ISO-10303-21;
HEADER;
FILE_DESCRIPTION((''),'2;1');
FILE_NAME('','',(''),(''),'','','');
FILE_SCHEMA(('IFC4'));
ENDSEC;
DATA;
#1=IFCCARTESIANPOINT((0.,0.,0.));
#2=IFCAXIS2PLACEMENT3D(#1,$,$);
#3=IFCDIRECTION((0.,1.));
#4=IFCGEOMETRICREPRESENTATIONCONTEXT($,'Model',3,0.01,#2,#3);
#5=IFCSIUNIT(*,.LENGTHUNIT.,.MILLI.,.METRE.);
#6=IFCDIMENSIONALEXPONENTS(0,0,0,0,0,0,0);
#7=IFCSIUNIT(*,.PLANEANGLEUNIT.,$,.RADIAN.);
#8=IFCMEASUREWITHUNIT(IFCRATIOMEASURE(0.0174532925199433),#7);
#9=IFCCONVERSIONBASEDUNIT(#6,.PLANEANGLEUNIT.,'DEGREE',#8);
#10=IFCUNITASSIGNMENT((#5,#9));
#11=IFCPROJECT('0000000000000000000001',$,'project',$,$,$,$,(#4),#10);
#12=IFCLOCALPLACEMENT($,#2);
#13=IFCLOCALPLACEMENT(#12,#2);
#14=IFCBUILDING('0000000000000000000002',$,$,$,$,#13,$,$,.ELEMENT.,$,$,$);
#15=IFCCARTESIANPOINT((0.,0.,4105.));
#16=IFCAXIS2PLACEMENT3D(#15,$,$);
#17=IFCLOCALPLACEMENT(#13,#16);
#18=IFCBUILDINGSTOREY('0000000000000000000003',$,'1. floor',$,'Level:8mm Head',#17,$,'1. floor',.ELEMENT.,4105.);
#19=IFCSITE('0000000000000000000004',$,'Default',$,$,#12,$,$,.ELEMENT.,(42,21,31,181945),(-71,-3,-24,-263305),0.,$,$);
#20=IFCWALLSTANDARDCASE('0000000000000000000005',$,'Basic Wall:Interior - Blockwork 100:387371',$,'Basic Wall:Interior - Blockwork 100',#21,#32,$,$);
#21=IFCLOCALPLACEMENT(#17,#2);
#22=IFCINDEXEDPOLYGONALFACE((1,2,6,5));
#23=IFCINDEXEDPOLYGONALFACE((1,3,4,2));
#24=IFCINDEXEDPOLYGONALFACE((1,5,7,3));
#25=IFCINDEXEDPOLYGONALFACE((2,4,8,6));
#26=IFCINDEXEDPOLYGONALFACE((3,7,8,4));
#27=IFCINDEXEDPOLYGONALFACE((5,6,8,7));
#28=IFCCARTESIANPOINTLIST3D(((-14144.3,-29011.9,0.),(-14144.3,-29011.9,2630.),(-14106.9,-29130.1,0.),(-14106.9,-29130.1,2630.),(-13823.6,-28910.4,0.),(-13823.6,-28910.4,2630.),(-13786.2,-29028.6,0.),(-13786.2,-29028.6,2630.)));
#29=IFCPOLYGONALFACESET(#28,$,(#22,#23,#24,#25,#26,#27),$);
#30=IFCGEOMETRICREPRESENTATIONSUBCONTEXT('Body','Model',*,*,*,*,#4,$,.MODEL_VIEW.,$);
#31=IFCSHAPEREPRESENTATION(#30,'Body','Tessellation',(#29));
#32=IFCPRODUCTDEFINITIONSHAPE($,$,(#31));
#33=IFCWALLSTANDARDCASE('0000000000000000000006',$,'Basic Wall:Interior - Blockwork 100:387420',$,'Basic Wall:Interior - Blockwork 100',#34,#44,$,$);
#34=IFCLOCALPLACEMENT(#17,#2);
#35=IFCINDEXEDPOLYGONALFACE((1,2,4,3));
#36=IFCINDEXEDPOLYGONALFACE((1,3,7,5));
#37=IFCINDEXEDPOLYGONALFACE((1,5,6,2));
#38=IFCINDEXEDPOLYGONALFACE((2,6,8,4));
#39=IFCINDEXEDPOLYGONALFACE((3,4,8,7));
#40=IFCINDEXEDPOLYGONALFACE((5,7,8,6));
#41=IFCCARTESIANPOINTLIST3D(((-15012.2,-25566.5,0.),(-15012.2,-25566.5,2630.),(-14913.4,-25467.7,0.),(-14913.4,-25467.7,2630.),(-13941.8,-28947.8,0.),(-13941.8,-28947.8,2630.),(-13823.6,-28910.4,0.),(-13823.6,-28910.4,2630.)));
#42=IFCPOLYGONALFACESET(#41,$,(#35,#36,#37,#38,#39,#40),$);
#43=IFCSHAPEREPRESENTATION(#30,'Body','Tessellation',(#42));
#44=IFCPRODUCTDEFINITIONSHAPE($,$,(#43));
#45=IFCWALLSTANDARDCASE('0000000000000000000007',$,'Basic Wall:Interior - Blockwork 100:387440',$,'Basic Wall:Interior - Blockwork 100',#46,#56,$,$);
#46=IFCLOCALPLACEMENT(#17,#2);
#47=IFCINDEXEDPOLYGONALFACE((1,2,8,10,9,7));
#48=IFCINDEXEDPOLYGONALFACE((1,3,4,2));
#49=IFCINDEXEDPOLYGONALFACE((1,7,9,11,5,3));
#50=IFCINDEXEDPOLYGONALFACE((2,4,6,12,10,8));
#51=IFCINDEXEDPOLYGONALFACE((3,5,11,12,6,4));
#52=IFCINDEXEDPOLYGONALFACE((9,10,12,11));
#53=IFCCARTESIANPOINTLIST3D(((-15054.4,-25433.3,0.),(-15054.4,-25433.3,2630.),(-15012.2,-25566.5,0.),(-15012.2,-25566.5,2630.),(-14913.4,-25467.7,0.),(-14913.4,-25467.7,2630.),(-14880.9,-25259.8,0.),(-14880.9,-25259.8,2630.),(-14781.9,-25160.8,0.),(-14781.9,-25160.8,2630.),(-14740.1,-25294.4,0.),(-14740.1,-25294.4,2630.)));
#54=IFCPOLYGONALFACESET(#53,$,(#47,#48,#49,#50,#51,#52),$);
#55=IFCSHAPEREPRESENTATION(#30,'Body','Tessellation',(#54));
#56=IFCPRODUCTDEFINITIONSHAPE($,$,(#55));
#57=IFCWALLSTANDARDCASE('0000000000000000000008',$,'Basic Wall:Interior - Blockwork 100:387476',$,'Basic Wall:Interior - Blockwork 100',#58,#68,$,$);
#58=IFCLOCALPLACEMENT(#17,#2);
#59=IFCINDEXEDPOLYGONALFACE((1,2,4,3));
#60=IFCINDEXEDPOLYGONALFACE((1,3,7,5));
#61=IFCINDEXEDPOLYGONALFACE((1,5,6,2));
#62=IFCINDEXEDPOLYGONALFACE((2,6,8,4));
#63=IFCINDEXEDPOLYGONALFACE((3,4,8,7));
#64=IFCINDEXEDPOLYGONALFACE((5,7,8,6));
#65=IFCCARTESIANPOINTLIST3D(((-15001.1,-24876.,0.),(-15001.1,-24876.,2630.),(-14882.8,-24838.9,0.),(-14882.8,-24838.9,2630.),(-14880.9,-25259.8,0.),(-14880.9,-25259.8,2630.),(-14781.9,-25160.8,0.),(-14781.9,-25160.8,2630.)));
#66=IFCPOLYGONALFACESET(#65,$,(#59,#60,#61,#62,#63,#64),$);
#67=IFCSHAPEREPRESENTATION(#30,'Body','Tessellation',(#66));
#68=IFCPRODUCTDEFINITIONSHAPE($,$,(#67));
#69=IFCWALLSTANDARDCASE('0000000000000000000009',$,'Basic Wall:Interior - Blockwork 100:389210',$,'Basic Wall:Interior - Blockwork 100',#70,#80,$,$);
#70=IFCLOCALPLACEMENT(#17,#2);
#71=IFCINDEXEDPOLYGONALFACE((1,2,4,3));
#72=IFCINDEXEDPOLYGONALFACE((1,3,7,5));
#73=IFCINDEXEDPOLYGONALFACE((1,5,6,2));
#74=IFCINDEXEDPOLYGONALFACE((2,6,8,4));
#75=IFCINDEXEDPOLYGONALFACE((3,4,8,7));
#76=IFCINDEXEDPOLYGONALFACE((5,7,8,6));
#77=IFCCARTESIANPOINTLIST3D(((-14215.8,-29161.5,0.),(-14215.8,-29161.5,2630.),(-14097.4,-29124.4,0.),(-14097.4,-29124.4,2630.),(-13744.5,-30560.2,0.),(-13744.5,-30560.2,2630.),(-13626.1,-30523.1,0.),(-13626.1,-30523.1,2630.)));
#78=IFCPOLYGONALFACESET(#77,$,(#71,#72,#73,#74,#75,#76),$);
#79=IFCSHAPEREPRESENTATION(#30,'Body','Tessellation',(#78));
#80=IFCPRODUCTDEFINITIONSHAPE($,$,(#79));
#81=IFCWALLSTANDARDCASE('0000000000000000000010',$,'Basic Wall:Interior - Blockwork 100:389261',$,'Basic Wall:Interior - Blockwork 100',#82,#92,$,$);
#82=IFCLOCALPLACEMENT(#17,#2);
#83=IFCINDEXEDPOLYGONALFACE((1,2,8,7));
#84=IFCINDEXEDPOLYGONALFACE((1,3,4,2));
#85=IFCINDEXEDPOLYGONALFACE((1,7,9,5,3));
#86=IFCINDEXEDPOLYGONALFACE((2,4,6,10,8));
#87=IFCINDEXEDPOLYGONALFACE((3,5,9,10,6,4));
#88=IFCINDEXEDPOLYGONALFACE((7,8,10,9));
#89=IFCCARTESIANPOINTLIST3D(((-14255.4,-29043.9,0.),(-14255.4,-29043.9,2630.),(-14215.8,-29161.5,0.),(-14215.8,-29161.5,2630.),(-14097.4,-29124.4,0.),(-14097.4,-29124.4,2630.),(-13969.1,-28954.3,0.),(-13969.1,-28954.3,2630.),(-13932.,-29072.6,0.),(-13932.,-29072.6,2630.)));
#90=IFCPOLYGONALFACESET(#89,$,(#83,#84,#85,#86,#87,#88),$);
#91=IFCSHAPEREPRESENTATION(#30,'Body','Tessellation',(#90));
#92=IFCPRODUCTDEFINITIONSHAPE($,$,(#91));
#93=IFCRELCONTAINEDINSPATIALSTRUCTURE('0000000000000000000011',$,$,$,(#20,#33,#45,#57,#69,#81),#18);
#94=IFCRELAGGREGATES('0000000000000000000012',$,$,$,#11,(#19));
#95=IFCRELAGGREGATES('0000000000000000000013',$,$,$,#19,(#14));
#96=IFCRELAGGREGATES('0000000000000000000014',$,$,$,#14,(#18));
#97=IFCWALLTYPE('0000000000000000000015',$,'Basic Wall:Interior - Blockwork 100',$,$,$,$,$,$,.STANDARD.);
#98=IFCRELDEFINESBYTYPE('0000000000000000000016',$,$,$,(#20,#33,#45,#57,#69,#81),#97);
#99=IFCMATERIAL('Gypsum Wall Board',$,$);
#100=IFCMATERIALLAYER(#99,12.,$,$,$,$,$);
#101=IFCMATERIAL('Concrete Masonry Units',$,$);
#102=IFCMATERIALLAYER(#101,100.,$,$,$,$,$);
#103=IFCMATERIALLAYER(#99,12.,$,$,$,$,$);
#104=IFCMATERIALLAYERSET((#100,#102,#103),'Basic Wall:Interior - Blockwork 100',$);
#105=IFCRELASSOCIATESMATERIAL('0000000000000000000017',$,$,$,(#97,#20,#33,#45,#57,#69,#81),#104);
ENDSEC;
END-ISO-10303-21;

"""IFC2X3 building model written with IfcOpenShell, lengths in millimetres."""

from ifc_helpers import new_model, entity, si_unit, converted_unit, direction, frame, frame_2d, origin, place, context, subcontext, project, spatial, polyline, rectangle, outline, extrude, material, layer, layer_set, layer_usage, type_object, element, save


model = new_model("IFC2X3")

# Units and contexts
model_context = context("Model", 3, precision=0.01, world=origin(), true_north=direction((0.0, 1.0)))
body_context = subcontext(model_context, "Body", "Model", "MODEL_VIEW")
ifc_project = project(units=[si_unit("LENGTHUNIT", "METRE", prefix="MILLI"), converted_unit("PLANEANGLEUNIT", "DEGREE", entity("IfcRatioMeasure", 0.0174532925199433), si_unit("PLANEANGLEUNIT", "RADIAN"), dimensions=[0, 0, 0, 0, 0, 0, 0])], contexts=[model_context])

# Site, building, storey
site_placement = place(None, origin())
site = spatial("IfcSite", under=ifc_project, at=site_placement, Name="Default", CompositionType="ELEMENT", RefLatitude=(42, 21, 31, 181945), RefLongitude=(-71, -3, -24, -263305), RefElevation=0.0)
building_placement = place(site_placement, origin())
building = spatial("IfcBuilding", under=site, at=building_placement, CompositionType="ELEMENT")
storey_placement = place(building_placement, frame((0.0, 0.0, 4105.0)))
storey = spatial("IfcBuildingStorey", under=building, at=storey_placement, Name="1. floor", ObjectType="Level:8mm Head", LongName="1. floor", CompositionType="ELEMENT", Elevation=4105.0)

# Shared definitions
ifc_material_1 = material(Name="Gypsum Wall Board")

# Walls
ifc_layer_1 = layer(ifc_material_1, 12.0)
ifc_material_2 = material(Name="Concrete Masonry Units")
ifc_layer_2 = layer(ifc_material_2, 100.0)
ifc_layer_3 = layer(ifc_material_1, 12.0)
ifc_layer_set_1 = layer_set([ifc_layer_1, ifc_layer_2, ifc_layer_3], Name="Basic Wall:Interior - Blockwork 100")
wall_type_1 = type_object("IfcWallType", Name="Basic Wall:Interior - Blockwork 100", PredefinedType="STANDARD", material=ifc_layer_set_1)
ifc_layer_usage_1 = layer_usage(ifc_layer_set_1, "AXIS2", "NEGATIVE", 62.0)
wall_1_placement = place(storey_placement, frame((-14125.6, -29071.0, 0.0), z_axis=(0.0, 0.0, 1.0), x_axis=(0.953372, 0.301797, 0.0)))
element("IfcWallStandardCase", 1, at=wall_1_placement, inside=storey, type_object=wall_type_1, material=ifc_layer_usage_1, Name="Basic Wall:Interior - Blockwork 100:387371", ObjectType="Basic Wall:Interior - Blockwork 100", context=body_context, shape_type="SweptSolid", body=[
    extrude(rectangle(XDim=336.4, YDim=124.0, at=frame_2d((168.2, 0.0), x_axis=(-1.0, 0.0))), origin(), (0.0, 0.0, 1.0), 2630.0),
])
ifc_layer_usage_2 = layer_usage(ifc_layer_set_1, "AXIS2", "NEGATIVE", 62.0)
wall_2_placement = place(storey_placement, frame((-13882.7, -28929.1, 0.0), z_axis=(0.0, 0.0, 1.0), x_axis=(-0.301797, 0.953372, 0.0)))
element("IfcWallStandardCase", 2, at=wall_2_placement, inside=storey, type_object=wall_type_1, material=ifc_layer_usage_2, Name="Basic Wall:Interior - Blockwork 100:387420", ObjectType="Basic Wall:Interior - Blockwork 100", context=body_context, shape_type="SweptSolid", body=[
    extrude(outline(polyline([(3611.1, -62.0), (3546.7, 62.0), (0.0, 62.0), (0.0, -62.0), (3611.1, -62.0)])), origin(), (0.0, 0.0, 1.0), 2630.0),
])
ifc_layer_usage_3 = layer_usage(ifc_layer_set_1, "AXIS2", "NEGATIVE", 62.0)
wall_3_placement = place(storey_placement, frame((-15056.0, -25522.6, 0.0), z_axis=(0.0, 0.0, 1.0), x_axis=(0.707107, 0.707107, 0.0)))
element("IfcWallStandardCase", 3, at=wall_3_placement, inside=storey, type_object=wall_type_1, material=ifc_layer_usage_3, Name="Basic Wall:Interior - Blockwork 100:387440", ObjectType="Basic Wall:Interior - Blockwork 100", context=body_context, shape_type="SweptSolid", body=[
    extrude(outline(polyline([(384.8, -62.0), (449.6, 62.0), (309.7, 62.0), (64.4, 62.0), (0.0, -62.0), (139.7, -62.0), (384.8, -62.0)])), origin(), (0.0, 0.0, 1.0), 2630.0),
])
ifc_layer_usage_4 = layer_usage(ifc_layer_set_1, "AXIS2", "NEGATIVE", 62.0)
wall_4_placement = place(storey_placement, frame((-14821.7, -25241.2, 0.0), z_axis=(0.0, 0.0, 1.0), x_axis=(-0.298924, 0.954277, 0.0)))
element("IfcWallStandardCase", 4, at=wall_4_placement, inside=storey, type_object=wall_type_1, material=ifc_layer_usage_4, Name="Basic Wall:Interior - Blockwork 100:387476", ObjectType="Basic Wall:Interior - Blockwork 100", context=body_context, shape_type="SweptSolid", body=[
    extrude(outline(polyline([(402.2, -62.0), (402.2, 62.0), (0.0, 62.0), (64.8, -62.0), (402.2, -62.0)])), origin(), (0.0, 0.0, 1.0), 2630.0),
])
ifc_layer_usage_5 = layer_usage(ifc_layer_set_1, "AXIS2", "NEGATIVE", 62.0)
wall_5_placement = place(storey_placement, frame((-13684.9, -30542.9, 0.0), z_axis=(0.0, 0.0, 1.0), x_axis=(-0.319293, 0.947656, 0.0)))
element("IfcWallStandardCase", 5, at=wall_5_placement, inside=storey, type_object=wall_type_1, material=ifc_layer_usage_5, Name="Basic Wall:Interior - Blockwork 100:389210", ObjectType="Basic Wall:Interior - Blockwork 100", context=body_context, shape_type="SweptSolid", body=[
    extrude(outline(polyline([(1476.0, -62.0), (1478.6, 62.0), (2.7, 62.0), (0.0, -62.0), (1476.0, -62.0)])), origin(), (0.0, 0.0, 1.0), 2630.0),
])
ifc_layer_usage_6 = layer_usage(ifc_layer_set_1, "AXIS2", "NEGATIVE", 62.0)
wall_6_placement = place(storey_placement, frame((-14236.8, -29103.1, 0.0), z_axis=(0.0, 0.0, 1.0), x_axis=(0.954277, 0.298924, 0.0)))
element("IfcWallStandardCase", 6, at=wall_6_placement, inside=storey, type_object=wall_type_1, material=ifc_layer_usage_6, Name="Basic Wall:Interior - Blockwork 100:389261", ObjectType="Basic Wall:Interior - Blockwork 100", context=body_context, shape_type="SweptSolid", body=[
    extrude(outline(polyline([(300.0, -62.0), (300.0, 62.0), (0.0, 62.0), (2.7, -62.0), (126.7, -62.0), (300.0, -62.0)])), origin(), (0.0, 0.0, 1.0), 2630.0),
])

save(model, "model.ifc")
